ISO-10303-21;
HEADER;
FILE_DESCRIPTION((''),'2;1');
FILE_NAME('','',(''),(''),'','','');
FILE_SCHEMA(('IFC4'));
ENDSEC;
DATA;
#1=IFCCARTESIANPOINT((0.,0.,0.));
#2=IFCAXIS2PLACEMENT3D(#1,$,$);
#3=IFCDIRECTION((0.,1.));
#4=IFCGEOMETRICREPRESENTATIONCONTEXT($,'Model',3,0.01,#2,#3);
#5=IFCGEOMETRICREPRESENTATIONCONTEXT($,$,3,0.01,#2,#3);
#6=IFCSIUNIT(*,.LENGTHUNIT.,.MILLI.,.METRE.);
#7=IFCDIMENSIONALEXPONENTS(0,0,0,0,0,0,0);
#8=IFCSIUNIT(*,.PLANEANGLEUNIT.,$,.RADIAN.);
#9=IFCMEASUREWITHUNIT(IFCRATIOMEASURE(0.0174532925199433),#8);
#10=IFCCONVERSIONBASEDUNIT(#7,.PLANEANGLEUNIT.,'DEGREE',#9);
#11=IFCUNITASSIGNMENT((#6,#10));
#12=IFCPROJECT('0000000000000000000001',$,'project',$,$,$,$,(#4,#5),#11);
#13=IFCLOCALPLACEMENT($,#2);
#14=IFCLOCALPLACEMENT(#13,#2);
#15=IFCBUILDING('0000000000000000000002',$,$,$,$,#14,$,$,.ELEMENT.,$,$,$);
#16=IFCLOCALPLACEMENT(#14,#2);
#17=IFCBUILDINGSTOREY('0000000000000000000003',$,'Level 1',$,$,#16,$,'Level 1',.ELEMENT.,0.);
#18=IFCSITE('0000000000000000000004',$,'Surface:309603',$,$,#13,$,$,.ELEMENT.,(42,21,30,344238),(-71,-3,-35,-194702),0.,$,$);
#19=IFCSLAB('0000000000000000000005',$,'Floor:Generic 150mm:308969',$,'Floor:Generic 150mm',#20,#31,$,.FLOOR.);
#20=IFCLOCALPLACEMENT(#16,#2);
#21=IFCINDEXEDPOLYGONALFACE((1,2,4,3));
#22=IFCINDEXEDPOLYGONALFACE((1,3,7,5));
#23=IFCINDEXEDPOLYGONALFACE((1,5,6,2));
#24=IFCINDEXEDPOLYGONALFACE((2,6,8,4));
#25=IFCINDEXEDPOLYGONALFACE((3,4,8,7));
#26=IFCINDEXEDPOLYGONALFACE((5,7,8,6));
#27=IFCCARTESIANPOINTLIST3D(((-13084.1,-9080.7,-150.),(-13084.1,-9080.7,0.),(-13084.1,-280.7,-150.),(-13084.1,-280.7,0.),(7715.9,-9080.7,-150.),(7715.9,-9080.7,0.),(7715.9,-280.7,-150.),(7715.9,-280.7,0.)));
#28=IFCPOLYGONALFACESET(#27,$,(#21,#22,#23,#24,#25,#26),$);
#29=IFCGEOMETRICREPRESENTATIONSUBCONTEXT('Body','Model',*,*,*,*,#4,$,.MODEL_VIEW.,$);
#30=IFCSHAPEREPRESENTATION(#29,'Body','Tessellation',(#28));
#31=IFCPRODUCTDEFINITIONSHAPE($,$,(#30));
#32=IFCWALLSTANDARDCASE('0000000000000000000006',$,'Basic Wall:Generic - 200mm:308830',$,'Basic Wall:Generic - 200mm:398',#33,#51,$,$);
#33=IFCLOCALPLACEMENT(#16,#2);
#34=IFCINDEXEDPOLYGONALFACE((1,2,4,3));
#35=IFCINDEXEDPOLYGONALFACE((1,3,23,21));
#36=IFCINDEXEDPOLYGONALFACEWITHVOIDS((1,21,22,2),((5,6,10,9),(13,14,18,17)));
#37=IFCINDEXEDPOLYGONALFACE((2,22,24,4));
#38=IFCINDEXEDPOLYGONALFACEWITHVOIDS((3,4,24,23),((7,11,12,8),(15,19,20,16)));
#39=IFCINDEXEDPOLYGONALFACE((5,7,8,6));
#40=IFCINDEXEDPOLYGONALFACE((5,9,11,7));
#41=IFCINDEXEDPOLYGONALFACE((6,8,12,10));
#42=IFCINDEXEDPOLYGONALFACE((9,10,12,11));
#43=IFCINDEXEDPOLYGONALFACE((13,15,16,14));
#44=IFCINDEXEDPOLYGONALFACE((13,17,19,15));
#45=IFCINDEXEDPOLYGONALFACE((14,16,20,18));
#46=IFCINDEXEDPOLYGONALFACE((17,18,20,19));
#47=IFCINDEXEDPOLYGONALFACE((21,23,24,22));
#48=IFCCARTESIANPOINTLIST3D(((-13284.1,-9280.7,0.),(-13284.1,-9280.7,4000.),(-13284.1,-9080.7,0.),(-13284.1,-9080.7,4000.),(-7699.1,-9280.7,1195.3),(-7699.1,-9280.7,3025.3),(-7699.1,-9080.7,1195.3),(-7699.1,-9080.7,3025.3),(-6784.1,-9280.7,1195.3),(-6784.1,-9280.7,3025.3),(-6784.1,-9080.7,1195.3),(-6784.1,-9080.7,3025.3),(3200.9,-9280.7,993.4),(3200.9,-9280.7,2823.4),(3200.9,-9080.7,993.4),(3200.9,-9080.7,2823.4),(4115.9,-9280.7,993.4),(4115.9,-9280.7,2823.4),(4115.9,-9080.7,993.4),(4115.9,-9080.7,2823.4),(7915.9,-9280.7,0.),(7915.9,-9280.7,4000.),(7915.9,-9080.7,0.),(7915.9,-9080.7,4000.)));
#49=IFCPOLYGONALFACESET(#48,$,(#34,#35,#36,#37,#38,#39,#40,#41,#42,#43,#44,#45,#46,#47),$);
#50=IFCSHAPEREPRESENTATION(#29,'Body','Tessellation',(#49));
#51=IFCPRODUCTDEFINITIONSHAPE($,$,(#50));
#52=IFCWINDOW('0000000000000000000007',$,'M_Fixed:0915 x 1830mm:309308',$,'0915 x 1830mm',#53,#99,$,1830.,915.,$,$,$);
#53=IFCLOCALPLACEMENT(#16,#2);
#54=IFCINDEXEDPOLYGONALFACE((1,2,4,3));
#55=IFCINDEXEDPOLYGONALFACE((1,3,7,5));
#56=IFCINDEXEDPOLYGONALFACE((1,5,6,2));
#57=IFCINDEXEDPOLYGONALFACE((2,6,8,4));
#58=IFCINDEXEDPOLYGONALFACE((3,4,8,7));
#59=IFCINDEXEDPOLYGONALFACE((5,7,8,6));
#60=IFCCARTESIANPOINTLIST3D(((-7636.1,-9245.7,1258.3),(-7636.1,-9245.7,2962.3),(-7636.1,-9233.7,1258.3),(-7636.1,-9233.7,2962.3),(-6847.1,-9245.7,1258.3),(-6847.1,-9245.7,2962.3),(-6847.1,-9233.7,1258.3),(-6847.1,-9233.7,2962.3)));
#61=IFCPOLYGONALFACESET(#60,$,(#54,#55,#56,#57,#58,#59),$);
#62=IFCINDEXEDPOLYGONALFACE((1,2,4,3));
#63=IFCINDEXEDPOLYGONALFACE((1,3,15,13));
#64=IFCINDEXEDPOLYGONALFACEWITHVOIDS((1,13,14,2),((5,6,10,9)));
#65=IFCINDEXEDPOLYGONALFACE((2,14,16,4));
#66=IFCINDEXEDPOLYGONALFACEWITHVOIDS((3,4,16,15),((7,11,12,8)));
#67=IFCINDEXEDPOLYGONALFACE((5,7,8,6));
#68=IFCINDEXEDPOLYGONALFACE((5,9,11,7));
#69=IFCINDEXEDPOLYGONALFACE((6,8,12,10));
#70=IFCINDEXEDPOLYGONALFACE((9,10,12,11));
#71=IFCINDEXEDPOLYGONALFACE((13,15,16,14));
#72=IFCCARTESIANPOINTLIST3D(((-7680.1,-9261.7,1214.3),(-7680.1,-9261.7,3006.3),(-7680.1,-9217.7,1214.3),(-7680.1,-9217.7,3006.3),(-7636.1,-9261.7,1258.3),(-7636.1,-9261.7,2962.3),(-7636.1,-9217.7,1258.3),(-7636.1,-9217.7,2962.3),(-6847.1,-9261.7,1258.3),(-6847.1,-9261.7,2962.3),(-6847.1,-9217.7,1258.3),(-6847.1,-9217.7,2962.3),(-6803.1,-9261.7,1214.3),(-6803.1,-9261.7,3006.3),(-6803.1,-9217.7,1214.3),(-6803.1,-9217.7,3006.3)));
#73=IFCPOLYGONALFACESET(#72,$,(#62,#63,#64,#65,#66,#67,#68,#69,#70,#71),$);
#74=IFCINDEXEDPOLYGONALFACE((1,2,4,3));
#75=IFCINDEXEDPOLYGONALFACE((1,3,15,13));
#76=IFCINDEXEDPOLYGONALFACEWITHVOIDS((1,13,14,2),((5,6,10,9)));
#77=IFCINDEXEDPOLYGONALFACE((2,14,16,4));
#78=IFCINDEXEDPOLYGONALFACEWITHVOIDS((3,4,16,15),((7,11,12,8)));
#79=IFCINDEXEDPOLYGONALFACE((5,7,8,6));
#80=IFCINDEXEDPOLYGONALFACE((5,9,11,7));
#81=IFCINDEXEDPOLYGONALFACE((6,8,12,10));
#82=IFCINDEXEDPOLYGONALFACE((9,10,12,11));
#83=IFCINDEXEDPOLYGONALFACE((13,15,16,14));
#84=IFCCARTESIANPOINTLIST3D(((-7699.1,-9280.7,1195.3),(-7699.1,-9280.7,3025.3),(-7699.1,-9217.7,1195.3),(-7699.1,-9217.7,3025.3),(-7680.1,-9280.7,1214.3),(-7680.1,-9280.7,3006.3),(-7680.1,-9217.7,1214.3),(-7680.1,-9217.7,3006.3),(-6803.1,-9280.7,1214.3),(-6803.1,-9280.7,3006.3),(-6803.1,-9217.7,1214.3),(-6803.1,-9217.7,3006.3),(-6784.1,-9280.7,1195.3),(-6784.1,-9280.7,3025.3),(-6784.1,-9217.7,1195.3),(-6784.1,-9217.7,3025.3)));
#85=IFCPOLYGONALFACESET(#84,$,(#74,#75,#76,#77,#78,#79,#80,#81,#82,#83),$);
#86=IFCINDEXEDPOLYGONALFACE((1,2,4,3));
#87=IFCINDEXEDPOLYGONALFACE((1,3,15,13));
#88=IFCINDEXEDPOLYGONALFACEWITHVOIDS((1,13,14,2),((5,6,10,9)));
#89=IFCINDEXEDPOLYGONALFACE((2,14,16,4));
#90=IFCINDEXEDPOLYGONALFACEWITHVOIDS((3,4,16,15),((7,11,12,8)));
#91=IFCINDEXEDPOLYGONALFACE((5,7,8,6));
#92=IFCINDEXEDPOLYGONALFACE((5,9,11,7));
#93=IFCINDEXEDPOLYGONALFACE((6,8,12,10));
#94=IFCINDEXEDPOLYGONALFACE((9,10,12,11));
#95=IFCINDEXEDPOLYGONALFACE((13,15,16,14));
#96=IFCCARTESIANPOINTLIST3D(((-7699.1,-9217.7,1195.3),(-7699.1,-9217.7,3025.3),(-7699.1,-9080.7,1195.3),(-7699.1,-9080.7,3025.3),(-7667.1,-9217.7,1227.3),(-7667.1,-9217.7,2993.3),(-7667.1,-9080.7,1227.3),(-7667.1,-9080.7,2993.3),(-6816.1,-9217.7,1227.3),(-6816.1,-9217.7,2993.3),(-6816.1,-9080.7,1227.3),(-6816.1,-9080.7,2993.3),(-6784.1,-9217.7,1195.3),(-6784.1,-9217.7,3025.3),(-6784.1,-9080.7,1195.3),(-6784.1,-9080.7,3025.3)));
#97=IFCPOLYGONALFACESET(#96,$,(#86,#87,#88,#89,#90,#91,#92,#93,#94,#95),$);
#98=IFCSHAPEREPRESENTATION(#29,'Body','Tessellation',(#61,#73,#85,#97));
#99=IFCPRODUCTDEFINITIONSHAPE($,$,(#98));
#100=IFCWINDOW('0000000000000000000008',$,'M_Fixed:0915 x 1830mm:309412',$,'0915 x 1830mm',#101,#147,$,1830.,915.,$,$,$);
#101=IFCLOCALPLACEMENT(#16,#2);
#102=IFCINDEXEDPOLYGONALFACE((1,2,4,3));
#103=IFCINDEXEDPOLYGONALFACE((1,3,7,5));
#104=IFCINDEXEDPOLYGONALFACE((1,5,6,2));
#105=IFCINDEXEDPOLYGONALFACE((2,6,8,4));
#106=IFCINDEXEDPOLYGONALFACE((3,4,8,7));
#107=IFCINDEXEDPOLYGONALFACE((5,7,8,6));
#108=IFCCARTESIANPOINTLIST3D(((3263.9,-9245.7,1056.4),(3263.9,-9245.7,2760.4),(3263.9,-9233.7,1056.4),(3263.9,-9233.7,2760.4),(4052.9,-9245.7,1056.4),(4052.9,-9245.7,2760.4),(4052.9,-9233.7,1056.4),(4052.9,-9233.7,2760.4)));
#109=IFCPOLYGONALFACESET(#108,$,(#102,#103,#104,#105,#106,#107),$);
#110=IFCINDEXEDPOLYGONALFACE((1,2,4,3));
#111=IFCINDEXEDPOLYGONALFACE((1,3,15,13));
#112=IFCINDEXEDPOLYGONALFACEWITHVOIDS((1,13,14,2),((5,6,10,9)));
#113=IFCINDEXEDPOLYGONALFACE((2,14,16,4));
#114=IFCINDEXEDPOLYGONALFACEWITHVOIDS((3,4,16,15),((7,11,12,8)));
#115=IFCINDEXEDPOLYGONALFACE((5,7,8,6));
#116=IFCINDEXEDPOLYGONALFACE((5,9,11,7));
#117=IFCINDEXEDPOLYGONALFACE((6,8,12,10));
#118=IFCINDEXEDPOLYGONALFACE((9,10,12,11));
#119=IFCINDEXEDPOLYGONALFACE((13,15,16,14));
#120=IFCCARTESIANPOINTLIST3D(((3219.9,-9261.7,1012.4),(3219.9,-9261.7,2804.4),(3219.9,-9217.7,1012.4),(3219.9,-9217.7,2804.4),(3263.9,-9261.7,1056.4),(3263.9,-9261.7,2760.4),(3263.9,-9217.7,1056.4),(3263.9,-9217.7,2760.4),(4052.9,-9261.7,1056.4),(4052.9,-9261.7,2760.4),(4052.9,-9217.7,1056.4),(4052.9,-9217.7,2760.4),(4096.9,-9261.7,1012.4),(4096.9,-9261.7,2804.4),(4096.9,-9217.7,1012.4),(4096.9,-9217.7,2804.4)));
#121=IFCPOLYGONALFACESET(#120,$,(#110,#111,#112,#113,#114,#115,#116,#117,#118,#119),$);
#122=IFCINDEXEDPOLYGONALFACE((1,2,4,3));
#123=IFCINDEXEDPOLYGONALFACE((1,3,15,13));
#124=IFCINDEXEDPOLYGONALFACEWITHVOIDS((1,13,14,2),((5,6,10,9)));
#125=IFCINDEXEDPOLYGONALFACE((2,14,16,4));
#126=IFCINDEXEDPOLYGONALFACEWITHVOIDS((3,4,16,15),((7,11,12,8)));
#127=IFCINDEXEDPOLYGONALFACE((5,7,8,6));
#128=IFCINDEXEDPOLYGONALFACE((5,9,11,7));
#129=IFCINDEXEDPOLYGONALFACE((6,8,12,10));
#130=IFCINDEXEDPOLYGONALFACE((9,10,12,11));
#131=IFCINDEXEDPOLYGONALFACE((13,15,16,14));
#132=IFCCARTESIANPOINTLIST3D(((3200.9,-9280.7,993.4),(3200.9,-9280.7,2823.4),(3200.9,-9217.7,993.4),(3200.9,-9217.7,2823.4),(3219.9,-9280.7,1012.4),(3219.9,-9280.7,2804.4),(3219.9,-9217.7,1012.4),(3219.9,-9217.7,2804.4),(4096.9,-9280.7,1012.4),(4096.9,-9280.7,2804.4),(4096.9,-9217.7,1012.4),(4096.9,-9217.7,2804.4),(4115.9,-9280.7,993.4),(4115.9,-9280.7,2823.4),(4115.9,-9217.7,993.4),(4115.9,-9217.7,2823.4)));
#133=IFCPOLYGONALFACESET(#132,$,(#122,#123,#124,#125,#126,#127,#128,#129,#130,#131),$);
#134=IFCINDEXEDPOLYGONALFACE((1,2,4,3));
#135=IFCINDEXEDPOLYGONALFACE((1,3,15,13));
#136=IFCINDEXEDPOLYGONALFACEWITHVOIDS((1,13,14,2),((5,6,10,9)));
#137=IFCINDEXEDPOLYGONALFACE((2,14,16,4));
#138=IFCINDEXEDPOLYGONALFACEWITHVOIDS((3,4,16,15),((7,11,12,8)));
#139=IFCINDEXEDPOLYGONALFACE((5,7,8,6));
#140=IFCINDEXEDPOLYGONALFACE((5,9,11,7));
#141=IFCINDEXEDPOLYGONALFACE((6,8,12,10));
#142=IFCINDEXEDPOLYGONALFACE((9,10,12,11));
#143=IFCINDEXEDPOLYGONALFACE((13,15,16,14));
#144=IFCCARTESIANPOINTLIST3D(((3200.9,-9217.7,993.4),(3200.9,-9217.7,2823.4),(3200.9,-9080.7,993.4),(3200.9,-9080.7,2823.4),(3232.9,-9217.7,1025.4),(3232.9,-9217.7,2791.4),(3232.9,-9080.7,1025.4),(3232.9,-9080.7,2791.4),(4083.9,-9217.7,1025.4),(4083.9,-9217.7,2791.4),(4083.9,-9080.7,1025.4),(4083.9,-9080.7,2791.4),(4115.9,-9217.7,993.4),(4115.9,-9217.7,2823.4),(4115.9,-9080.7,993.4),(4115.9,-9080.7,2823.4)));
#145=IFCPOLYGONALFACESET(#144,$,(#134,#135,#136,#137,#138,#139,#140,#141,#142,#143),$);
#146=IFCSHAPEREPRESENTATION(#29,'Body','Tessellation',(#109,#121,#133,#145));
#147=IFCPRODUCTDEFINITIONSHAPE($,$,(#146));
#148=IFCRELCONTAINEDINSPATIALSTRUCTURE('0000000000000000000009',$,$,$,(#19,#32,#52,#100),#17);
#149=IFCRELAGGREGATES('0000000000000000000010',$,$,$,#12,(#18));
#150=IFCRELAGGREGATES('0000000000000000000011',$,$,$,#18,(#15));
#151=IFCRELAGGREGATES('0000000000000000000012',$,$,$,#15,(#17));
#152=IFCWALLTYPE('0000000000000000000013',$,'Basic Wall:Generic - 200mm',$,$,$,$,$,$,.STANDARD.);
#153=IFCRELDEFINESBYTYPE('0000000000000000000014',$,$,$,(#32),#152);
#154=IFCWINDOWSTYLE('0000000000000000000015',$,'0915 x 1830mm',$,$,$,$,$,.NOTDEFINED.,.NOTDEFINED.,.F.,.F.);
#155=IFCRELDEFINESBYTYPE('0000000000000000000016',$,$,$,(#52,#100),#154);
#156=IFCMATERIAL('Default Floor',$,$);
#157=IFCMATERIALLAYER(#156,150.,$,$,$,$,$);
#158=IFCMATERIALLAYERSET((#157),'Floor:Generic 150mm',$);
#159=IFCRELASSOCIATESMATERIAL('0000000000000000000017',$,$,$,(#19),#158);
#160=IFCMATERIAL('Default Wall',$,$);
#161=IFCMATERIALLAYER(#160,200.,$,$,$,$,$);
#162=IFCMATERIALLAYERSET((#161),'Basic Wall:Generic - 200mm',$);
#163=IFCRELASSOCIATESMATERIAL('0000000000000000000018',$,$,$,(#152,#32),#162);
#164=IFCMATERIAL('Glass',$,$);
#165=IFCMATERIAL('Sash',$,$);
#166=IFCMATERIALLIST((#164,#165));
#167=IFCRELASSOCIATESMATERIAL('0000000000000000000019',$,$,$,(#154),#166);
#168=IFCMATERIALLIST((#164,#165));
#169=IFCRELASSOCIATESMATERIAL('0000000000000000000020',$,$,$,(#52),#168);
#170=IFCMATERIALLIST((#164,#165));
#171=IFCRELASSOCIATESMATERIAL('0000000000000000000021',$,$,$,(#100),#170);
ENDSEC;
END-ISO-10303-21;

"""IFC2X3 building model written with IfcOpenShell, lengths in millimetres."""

from ifc_helpers import new_model, entity, si_unit, converted_unit, direction, frame, frame_2d, origin, place, context, subcontext, project, spatial, polyline, rectangle, outline, extrude, source, transform, mapped, material, material_list, layer, layer_set, layer_usage, type_object, type_shapes, element, fill, save


model = new_model("IFC2X3")

# Units and contexts
model_context = context("Model", 3, precision=0.01, world=origin(), true_north=direction((0.0, 1.0)))
context_of_model = context(None, 3, precision=0.01, world=origin(), true_north=direction((0.0, 1.0)))
body_context = subcontext(model_context, "Body", "Model", "MODEL_VIEW")
ifc_project = project(units=[si_unit("LENGTHUNIT", "METRE", prefix="MILLI"), converted_unit("PLANEANGLEUNIT", "DEGREE", entity("IfcRatioMeasure", 0.0174532925199433), si_unit("PLANEANGLEUNIT", "RADIAN"), dimensions=[0, 0, 0, 0, 0, 0, 0])], contexts=[model_context, context_of_model])

# Site, building, storey
site_placement = place(None, origin())
site = spatial("IfcSite", under=ifc_project, at=site_placement, Name="Surface:309603", CompositionType="ELEMENT", RefLatitude=(42, 21, 30, 344238), RefLongitude=(-71, -3, -35, -194702), RefElevation=0.0)
building_placement = place(site_placement, origin())
building = spatial("IfcBuilding", under=site, at=building_placement, CompositionType="ELEMENT")
storey_placement = place(building_placement, origin())
storey = spatial("IfcBuildingStorey", under=building, at=storey_placement, Name="Level 1", LongName="Level 1", CompositionType="ELEMENT", Elevation=0.0)

# Slab
ifc_material_1 = material(Name="Default Floor")
ifc_layer_1 = layer(ifc_material_1, 150.0)
ifc_layer_set_1 = layer_set([ifc_layer_1], Name="Floor:Generic 150mm")
ifc_layer_usage_1 = layer_usage(ifc_layer_set_1, "AXIS3", "POSITIVE", 0.0)
slab_placement = place(storey_placement, origin())
element("IfcSlab", 1, at=slab_placement, inside=storey, material=ifc_layer_usage_1, Name="Floor:Generic 150mm:308969", ObjectType="Floor:Generic 150mm", PredefinedType="FLOOR", context=body_context, shape_type="SweptSolid", body=[
    extrude(rectangle(XDim=8800.0, YDim=20800.0, at=frame_2d((0.0, 0.0), x_axis=(1.0, 0.0))), frame((-2684.1, -4680.7, 0.0), z_axis=(0.0, 0.0, -1.0), x_axis=(0.0, 1.0, 0.0)), (0.0, 0.0, 1.0), 150.0),
])

# Wall, openings, windows
ifc_material_2 = material(Name="Default Wall")
ifc_layer_2 = layer(ifc_material_2, 200.0)
ifc_layer_set_2 = layer_set([ifc_layer_2], Name="Basic Wall:Generic - 200mm")
ifc_layer_usage_2 = layer_usage(ifc_layer_set_2, "AXIS2", "NEGATIVE", 100.0)
wall_type = type_object("IfcWallType", Name="Basic Wall:Generic - 200mm", PredefinedType="STANDARD", material=ifc_layer_set_2)
wall_1_placement = place(storey_placement, frame((-13284.1, -9180.7, 0.0)))
wall_1 = element("IfcWallStandardCase", 2, at=wall_1_placement, inside=storey, type_object=wall_type, material=ifc_layer_usage_2, Name="Basic Wall:Generic - 200mm:308830", ObjectType="Basic Wall:Generic - 200mm:398", context=body_context, shape_type="SweptSolid", body=[
    extrude(rectangle(XDim=21200.0, YDim=200.0, at=frame_2d((10600.0, 0.0), x_axis=(-1.0, 0.0))), origin(), (0.0, 0.0, 1.0), 4000.0),
])
opening_1_placement = place(wall_1_placement, frame((6500.0, 100.0, 1195.3)))
opening_1 = element("IfcOpeningElement", 3, at=opening_1_placement, cuts=wall_1, ObjectType="Opening", context=body_context, shape_type="SweptSolid", body=[
    extrude(rectangle(XDim=1830.0, YDim=915.0, at=frame_2d((915.0, 457.5), x_axis=(1.0, 0.0))), frame((0.0, 0.0, 0.0), z_axis=(0.0, -1.0, 0.0), x_axis=(0.0, 0.0, 1.0)), (0.0, 0.0, 1.0), 200.0),
])
opening_2_placement = place(wall_1_placement, frame((17400.0, 100.0, 993.4)))
opening_2 = element("IfcOpeningElement", 4, at=opening_2_placement, cuts=wall_1, ObjectType="Opening", context=body_context, shape_type="SweptSolid", body=[
    extrude(rectangle(XDim=1830.0, YDim=915.0, at=frame_2d((915.0, 457.5), x_axis=(1.0, 0.0))), frame((0.0, 0.0, 0.0), z_axis=(0.0, -1.0, 0.0), x_axis=(0.0, 0.0, 1.0)), (0.0, 0.0, 1.0), 200.0),
])
ifc_material_3 = material(Name="Glass")
ifc_material_4 = material(Name="Sash")
ifc_material_list_1 = material_list([ifc_material_3, ifc_material_4])
ifc_material_list_2 = material_list([ifc_material_3, ifc_material_4])
window_style = type_object("IfcWindowStyle", Name="0915 x 1830mm", ConstructionType="NOTDEFINED", OperationType="NOTDEFINED", ParameterTakesPrecedence=False, Sizeable=False, material=ifc_material_list_2)
shared_shape_1 = source(origin(), body_context, "Body", "SweptSolid", [
    extrude(rectangle(XDim=12.0, YDim=789.0, at=frame_2d((0.0, 0.0), x_axis=(1.0, 0.0))), frame((457.5, 159.0, 63.0), z_axis=(0.0, 0.0, 1.0), x_axis=(0.0, -1.0, 0.0)), (0.0, 0.0, 1.0), 1704.0),
    extrude(outline(polyline([(-438.5, -896.0), (438.5, -896.0), (438.5, 896.0), (-438.5, 896.0), (-438.5, -896.0)]), holes=[polyline([(-394.5, -852.0), (-394.5, 852.0), (394.5, 852.0), (394.5, -852.0), (-394.5, -852.0)])]), frame((457.5, 137.0, 915.0), z_axis=(0.0, 1.0, 0.0), x_axis=(1.0, 0.0, 0.0)), (0.0, 0.0, 1.0), 44.0),
    extrude(outline(polyline([(-457.5, -915.0), (457.5, -915.0), (457.5, 915.0), (-457.5, 915.0), (-457.5, -915.0)]), holes=[polyline([(-438.5, -896.0), (-438.5, 896.0), (438.5, 896.0), (438.5, -896.0), (-438.5, -896.0)])]), frame((457.5, 137.0, 915.0), z_axis=(0.0, 1.0, 0.0), x_axis=(1.0, 0.0, 0.0)), (0.0, 0.0, 1.0), 63.0),
    extrude(outline(polyline([(-457.5, -915.0), (457.5, -915.0), (457.5, 915.0), (-457.5, 915.0), (-457.5, -915.0)]), holes=[polyline([(-425.5, -883.0), (-425.5, 883.0), (425.5, 883.0), (425.5, -883.0), (-425.5, -883.0)])]), frame((457.5, 0.0, 915.0), z_axis=(0.0, 1.0, 0.0), x_axis=(1.0, 0.0, 0.0)), (0.0, 0.0, 1.0), 137.0),
])
type_shapes(window_style, [shared_shape_1])
window_1_placement = place(opening_1_placement, frame((0.0, 0.0, 0.0), z_axis=(0.0, 0.0, 1.0), x_axis=(-1.0, 0.0, 0.0)))
window_1 = element("IfcWindow", 5, at=window_1_placement, inside=storey, type_object=window_style, material=ifc_material_list_1, Name="M_Fixed:0915 x 1830mm:309308", ObjectType="0915 x 1830mm", OverallHeight=1830.0, OverallWidth=915.0, context=body_context, shape_type="MappedRepresentation", body=[
    mapped(shared_shape_1, transform((0.0, 0.0, 0.0), scale=1.0)),
])
fill(opening_1, window_1)
ifc_material_list_3 = material_list([ifc_material_3, ifc_material_4])
window_2_placement = place(opening_2_placement, frame((0.0, 0.0, 0.0), z_axis=(0.0, 0.0, 1.0), x_axis=(-1.0, 0.0, 0.0)))
window_2 = element("IfcWindow", 6, at=window_2_placement, inside=storey, type_object=window_style, material=ifc_material_list_3, Name="M_Fixed:0915 x 1830mm:309412", ObjectType="0915 x 1830mm", OverallHeight=1830.0, OverallWidth=915.0, context=body_context, shape_type="MappedRepresentation", body=[
    mapped(shared_shape_1, transform((0.0, 0.0, 0.0), scale=1.0)),
])
fill(opening_2, window_2)

save(model, "model.ifc")
